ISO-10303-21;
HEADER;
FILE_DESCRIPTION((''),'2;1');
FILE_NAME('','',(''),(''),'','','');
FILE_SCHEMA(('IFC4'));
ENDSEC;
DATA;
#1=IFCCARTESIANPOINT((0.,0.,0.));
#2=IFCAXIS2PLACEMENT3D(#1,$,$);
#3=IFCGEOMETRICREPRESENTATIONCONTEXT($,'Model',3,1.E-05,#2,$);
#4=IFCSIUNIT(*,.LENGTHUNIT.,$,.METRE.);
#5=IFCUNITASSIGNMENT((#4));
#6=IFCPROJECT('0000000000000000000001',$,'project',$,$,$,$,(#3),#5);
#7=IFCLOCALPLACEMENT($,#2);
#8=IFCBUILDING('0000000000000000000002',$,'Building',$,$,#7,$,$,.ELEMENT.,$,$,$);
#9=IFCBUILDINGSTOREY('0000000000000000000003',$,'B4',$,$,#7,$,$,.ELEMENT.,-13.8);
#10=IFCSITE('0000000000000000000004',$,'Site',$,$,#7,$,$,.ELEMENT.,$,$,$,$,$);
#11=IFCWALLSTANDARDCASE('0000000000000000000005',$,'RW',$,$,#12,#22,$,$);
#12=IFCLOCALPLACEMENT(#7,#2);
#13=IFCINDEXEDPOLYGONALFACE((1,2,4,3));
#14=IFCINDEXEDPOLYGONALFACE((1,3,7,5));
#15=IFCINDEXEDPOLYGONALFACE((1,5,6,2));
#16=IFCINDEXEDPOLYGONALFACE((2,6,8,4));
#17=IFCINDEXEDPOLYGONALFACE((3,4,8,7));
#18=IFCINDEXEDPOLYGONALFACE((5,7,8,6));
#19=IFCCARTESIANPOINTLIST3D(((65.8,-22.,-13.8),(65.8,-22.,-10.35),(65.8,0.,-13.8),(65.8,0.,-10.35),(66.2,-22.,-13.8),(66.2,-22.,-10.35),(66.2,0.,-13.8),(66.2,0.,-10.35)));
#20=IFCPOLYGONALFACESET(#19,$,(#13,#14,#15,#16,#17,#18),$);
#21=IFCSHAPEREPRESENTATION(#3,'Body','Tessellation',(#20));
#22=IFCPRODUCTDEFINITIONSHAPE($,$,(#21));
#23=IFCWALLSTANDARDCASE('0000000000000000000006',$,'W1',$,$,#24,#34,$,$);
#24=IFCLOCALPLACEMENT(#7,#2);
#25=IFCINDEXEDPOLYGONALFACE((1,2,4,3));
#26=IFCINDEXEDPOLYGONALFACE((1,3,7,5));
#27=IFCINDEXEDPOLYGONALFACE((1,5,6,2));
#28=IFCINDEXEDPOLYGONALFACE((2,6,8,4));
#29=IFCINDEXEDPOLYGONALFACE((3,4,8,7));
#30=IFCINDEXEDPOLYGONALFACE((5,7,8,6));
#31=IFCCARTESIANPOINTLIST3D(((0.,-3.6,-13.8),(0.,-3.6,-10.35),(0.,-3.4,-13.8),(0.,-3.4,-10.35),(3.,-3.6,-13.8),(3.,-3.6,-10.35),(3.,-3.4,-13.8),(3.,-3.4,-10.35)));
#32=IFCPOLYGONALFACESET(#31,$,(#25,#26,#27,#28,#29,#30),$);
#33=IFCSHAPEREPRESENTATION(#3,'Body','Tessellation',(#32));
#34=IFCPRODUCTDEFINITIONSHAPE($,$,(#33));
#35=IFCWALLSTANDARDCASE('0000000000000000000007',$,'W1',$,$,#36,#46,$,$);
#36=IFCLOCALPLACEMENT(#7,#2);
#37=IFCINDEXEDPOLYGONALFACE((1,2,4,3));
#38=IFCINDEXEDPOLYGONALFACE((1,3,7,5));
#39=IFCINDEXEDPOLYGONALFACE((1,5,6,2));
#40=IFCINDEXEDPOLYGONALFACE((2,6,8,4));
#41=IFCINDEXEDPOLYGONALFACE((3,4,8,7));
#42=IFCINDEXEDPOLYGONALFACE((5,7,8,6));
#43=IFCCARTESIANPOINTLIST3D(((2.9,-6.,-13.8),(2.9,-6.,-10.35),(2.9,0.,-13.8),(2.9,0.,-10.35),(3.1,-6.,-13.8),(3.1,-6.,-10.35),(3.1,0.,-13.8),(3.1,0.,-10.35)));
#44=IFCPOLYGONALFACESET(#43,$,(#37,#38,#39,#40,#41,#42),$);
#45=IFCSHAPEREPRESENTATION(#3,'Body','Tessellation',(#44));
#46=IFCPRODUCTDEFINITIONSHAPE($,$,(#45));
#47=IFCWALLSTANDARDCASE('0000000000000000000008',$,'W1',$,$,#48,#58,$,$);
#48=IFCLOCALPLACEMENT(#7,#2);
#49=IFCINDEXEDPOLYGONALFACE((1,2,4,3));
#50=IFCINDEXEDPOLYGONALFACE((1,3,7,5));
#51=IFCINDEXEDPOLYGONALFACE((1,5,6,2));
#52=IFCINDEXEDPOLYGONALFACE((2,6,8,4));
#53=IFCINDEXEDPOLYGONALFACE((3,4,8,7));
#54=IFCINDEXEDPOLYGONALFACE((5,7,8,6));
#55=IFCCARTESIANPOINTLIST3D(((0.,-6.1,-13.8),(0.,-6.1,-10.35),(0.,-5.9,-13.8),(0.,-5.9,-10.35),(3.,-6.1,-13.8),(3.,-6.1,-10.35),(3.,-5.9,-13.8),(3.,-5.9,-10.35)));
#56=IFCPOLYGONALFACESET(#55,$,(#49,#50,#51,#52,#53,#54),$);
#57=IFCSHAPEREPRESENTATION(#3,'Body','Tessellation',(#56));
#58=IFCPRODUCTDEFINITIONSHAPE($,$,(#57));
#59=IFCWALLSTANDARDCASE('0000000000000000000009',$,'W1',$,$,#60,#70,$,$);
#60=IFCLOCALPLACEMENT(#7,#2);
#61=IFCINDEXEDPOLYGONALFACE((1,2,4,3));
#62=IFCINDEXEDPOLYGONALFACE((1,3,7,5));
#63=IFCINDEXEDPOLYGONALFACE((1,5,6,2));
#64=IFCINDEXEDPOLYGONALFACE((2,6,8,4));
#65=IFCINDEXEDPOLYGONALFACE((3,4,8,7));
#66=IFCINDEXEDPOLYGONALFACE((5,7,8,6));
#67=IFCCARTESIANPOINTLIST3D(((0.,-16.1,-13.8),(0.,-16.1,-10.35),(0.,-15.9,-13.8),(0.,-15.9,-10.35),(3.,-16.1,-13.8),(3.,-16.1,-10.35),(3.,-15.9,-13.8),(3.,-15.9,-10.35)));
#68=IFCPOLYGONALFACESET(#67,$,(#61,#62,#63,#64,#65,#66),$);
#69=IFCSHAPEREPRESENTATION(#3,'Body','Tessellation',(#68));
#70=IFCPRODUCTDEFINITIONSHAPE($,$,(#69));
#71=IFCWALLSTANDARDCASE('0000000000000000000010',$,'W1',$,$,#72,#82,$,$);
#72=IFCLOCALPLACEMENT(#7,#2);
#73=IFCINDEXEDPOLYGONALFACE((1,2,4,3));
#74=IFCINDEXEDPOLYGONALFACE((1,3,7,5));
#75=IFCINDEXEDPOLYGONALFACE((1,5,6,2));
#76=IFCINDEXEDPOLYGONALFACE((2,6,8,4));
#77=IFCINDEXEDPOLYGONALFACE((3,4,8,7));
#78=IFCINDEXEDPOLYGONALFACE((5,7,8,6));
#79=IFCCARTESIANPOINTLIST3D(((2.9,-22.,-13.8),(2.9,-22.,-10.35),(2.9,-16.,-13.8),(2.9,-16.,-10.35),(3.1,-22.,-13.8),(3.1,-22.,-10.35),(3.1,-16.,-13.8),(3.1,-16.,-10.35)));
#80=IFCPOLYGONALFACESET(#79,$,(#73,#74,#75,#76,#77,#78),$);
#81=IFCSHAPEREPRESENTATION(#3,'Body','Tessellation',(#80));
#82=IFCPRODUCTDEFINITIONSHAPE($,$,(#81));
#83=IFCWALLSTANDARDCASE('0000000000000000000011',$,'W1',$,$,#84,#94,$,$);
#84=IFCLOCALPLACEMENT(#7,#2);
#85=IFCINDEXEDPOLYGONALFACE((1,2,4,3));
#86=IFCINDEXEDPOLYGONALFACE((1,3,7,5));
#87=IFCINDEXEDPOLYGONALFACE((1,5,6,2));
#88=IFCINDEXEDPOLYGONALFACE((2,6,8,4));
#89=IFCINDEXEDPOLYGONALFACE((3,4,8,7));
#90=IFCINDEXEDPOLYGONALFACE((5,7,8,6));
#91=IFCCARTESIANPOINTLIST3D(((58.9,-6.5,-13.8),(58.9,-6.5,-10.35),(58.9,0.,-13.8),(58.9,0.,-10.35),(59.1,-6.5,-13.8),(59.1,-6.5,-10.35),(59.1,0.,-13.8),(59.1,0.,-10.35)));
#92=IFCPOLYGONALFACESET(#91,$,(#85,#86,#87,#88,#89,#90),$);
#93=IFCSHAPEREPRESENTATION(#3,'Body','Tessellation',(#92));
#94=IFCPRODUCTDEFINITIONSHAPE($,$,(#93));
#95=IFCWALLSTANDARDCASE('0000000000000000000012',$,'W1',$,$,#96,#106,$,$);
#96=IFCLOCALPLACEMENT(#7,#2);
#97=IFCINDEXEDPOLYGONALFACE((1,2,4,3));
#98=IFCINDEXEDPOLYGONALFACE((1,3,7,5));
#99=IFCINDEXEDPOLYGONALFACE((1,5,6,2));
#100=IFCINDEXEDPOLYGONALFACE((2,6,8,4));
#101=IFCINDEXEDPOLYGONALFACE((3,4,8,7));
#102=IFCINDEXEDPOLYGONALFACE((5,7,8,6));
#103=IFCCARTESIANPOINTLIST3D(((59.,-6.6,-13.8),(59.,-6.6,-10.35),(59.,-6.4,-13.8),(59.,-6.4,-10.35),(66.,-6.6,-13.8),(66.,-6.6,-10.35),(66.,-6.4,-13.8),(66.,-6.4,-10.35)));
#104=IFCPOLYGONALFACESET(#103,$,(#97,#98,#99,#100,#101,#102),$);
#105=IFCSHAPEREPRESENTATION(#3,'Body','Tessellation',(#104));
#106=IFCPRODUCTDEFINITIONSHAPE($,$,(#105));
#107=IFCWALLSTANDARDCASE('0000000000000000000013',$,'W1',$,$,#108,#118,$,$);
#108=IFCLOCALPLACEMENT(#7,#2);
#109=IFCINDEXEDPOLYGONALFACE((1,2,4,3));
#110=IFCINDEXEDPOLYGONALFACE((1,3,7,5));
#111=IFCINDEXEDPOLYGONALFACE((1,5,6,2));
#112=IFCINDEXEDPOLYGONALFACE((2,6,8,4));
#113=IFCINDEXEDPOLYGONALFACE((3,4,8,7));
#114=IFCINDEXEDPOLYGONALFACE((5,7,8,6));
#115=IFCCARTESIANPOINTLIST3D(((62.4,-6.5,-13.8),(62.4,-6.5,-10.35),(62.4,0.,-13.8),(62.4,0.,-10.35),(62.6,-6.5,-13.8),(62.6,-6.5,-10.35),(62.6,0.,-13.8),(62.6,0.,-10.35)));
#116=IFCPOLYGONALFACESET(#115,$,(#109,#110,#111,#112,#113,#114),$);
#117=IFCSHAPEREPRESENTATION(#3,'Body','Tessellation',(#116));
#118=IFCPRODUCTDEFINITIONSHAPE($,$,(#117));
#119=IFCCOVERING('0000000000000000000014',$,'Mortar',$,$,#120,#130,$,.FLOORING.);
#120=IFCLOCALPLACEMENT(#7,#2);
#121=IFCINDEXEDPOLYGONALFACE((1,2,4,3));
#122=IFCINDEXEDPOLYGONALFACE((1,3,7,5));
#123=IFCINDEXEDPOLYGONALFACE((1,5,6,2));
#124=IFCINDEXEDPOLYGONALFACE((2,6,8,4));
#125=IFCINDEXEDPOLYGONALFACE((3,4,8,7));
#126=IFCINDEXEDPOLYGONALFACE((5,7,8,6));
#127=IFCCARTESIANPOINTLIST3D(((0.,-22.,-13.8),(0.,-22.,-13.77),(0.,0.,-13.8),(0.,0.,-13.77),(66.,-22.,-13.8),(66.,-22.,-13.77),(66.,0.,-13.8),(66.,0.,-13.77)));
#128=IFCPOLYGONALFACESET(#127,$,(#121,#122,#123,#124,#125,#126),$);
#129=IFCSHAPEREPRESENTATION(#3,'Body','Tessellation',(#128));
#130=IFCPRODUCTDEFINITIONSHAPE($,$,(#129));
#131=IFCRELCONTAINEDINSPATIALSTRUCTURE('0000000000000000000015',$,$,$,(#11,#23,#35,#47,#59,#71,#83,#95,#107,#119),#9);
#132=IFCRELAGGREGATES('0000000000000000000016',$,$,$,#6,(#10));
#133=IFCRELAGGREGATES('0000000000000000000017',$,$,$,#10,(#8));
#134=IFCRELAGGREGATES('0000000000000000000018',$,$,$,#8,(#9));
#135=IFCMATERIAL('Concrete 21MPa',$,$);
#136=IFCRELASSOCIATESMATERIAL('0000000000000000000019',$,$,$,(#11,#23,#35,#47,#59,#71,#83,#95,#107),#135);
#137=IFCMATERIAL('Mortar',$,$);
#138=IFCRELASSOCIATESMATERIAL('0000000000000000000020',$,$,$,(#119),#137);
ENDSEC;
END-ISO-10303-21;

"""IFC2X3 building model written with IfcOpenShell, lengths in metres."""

from ifc_helpers import new_model, si_unit, frame, origin, origin_2d, place, context, project, spatial, rectangle, extrude, material, element, save


model = new_model("IFC2X3")

# Units and contexts
model_context = context("Model", 3, precision=1e-05, world=origin())
ifc_project = project(units=[si_unit("LENGTHUNIT", "METRE")], contexts=[model_context])

# Site, building, storey
placement = place(None, origin())
site = spatial("IfcSite", under=ifc_project, at=placement, Name="Site", CompositionType="ELEMENT")
building = spatial("IfcBuilding", under=site, at=placement, Name="Building", CompositionType="ELEMENT")
storey = spatial("IfcBuildingStorey", under=building, at=placement, Name="B4", CompositionType="ELEMENT", Elevation=-13.8)

# Shared definitions
ifc_material_1 = material(Name="Concrete 21MPa")

# Walls
for number, where, name in (
    (1, (66.0, -11.0, -13.8), "RW"),
):
    element("IfcWallStandardCase", number, at=place(None, frame(where)), inside=storey, material=ifc_material_1, Name=name, context=model_context, shape_type="SweptSolid", body=[
        extrude(rectangle(XDim=0.4, YDim=22.0, at=origin_2d()), origin(), (0.0, 0.0, 1.0), 3.45),
    ])
wall_1_placement = place(None, frame((1.5, -3.5, -13.8)))
element("IfcWallStandardCase", 2, at=wall_1_placement, inside=storey, material=ifc_material_1, Name="W1", context=model_context, shape_type="SweptSolid", body=[
    extrude(rectangle(XDim=3.0, YDim=0.2, at=origin_2d()), origin(), (0.0, 0.0, 1.0), 3.45),
])
wall_2_placement = place(None, frame((3.0, -3.0, -13.8)))
element("IfcWallStandardCase", 3, at=wall_2_placement, inside=storey, material=ifc_material_1, Name="W1", context=model_context, shape_type="SweptSolid", body=[
    extrude(rectangle(XDim=0.2, YDim=6.0, at=origin_2d()), origin(), (0.0, 0.0, 1.0), 3.45),
])
for number, where, name in (
    (4, (1.5, -6.0, -13.8), "W1"),
    (5, (1.5, -16.0, -13.8), "W1"),
):
    element("IfcWallStandardCase", number, at=place(None, frame(where)), inside=storey, material=ifc_material_1, Name=name, context=model_context, shape_type="SweptSolid", body=[
        extrude(rectangle(XDim=3.0, YDim=0.2, at=origin_2d()), origin(), (0.0, 0.0, 1.0), 3.45),
    ])
wall_3_placement = place(None, frame((3.0, -19.0, -13.8)))
element("IfcWallStandardCase", 6, at=wall_3_placement, inside=storey, material=ifc_material_1, Name="W1", context=model_context, shape_type="SweptSolid", body=[
    extrude(rectangle(XDim=0.2, YDim=6.0, at=origin_2d()), origin(), (0.0, 0.0, 1.0), 3.45),
])
wall_4_placement = place(None, frame((59.0, -3.25, -13.8)))
element("IfcWallStandardCase", 7, at=wall_4_placement, inside=storey, material=ifc_material_1, Name="W1", context=model_context, shape_type="SweptSolid", body=[
    extrude(rectangle(XDim=0.2, YDim=6.5, at=origin_2d()), origin(), (0.0, 0.0, 1.0), 3.45),
])
wall_5_placement = place(None, frame((62.5, -6.5, -13.8)))
element("IfcWallStandardCase", 8, at=wall_5_placement, inside=storey, material=ifc_material_1, Name="W1", context=model_context, shape_type="SweptSolid", body=[
    extrude(rectangle(XDim=7.0, YDim=0.2, at=origin_2d()), origin(), (0.0, 0.0, 1.0), 3.45),
])
wall_6_placement = place(None, frame((62.5, -3.25, -13.8)))
element("IfcWallStandardCase", 9, at=wall_6_placement, inside=storey, material=ifc_material_1, Name="W1", context=model_context, shape_type="SweptSolid", body=[
    extrude(rectangle(XDim=0.2, YDim=6.5, at=origin_2d()), origin(), (0.0, 0.0, 1.0), 3.45),
])

# Covering
ifc_material_2 = material(Name="Mortar")
covering_placement = place(None, frame((33.0, -11.0, -13.8)))
element("IfcCovering", 10, at=covering_placement, inside=storey, material=ifc_material_2, Name="Mortar", PredefinedType="FLOORING", context=model_context, shape_type="SweptSolid", body=[
    extrude(rectangle(XDim=66.0, YDim=22.0, at=origin_2d()), origin(), (0.0, 0.0, 1.0), 0.03),
])

save(model, "model.ifc")
